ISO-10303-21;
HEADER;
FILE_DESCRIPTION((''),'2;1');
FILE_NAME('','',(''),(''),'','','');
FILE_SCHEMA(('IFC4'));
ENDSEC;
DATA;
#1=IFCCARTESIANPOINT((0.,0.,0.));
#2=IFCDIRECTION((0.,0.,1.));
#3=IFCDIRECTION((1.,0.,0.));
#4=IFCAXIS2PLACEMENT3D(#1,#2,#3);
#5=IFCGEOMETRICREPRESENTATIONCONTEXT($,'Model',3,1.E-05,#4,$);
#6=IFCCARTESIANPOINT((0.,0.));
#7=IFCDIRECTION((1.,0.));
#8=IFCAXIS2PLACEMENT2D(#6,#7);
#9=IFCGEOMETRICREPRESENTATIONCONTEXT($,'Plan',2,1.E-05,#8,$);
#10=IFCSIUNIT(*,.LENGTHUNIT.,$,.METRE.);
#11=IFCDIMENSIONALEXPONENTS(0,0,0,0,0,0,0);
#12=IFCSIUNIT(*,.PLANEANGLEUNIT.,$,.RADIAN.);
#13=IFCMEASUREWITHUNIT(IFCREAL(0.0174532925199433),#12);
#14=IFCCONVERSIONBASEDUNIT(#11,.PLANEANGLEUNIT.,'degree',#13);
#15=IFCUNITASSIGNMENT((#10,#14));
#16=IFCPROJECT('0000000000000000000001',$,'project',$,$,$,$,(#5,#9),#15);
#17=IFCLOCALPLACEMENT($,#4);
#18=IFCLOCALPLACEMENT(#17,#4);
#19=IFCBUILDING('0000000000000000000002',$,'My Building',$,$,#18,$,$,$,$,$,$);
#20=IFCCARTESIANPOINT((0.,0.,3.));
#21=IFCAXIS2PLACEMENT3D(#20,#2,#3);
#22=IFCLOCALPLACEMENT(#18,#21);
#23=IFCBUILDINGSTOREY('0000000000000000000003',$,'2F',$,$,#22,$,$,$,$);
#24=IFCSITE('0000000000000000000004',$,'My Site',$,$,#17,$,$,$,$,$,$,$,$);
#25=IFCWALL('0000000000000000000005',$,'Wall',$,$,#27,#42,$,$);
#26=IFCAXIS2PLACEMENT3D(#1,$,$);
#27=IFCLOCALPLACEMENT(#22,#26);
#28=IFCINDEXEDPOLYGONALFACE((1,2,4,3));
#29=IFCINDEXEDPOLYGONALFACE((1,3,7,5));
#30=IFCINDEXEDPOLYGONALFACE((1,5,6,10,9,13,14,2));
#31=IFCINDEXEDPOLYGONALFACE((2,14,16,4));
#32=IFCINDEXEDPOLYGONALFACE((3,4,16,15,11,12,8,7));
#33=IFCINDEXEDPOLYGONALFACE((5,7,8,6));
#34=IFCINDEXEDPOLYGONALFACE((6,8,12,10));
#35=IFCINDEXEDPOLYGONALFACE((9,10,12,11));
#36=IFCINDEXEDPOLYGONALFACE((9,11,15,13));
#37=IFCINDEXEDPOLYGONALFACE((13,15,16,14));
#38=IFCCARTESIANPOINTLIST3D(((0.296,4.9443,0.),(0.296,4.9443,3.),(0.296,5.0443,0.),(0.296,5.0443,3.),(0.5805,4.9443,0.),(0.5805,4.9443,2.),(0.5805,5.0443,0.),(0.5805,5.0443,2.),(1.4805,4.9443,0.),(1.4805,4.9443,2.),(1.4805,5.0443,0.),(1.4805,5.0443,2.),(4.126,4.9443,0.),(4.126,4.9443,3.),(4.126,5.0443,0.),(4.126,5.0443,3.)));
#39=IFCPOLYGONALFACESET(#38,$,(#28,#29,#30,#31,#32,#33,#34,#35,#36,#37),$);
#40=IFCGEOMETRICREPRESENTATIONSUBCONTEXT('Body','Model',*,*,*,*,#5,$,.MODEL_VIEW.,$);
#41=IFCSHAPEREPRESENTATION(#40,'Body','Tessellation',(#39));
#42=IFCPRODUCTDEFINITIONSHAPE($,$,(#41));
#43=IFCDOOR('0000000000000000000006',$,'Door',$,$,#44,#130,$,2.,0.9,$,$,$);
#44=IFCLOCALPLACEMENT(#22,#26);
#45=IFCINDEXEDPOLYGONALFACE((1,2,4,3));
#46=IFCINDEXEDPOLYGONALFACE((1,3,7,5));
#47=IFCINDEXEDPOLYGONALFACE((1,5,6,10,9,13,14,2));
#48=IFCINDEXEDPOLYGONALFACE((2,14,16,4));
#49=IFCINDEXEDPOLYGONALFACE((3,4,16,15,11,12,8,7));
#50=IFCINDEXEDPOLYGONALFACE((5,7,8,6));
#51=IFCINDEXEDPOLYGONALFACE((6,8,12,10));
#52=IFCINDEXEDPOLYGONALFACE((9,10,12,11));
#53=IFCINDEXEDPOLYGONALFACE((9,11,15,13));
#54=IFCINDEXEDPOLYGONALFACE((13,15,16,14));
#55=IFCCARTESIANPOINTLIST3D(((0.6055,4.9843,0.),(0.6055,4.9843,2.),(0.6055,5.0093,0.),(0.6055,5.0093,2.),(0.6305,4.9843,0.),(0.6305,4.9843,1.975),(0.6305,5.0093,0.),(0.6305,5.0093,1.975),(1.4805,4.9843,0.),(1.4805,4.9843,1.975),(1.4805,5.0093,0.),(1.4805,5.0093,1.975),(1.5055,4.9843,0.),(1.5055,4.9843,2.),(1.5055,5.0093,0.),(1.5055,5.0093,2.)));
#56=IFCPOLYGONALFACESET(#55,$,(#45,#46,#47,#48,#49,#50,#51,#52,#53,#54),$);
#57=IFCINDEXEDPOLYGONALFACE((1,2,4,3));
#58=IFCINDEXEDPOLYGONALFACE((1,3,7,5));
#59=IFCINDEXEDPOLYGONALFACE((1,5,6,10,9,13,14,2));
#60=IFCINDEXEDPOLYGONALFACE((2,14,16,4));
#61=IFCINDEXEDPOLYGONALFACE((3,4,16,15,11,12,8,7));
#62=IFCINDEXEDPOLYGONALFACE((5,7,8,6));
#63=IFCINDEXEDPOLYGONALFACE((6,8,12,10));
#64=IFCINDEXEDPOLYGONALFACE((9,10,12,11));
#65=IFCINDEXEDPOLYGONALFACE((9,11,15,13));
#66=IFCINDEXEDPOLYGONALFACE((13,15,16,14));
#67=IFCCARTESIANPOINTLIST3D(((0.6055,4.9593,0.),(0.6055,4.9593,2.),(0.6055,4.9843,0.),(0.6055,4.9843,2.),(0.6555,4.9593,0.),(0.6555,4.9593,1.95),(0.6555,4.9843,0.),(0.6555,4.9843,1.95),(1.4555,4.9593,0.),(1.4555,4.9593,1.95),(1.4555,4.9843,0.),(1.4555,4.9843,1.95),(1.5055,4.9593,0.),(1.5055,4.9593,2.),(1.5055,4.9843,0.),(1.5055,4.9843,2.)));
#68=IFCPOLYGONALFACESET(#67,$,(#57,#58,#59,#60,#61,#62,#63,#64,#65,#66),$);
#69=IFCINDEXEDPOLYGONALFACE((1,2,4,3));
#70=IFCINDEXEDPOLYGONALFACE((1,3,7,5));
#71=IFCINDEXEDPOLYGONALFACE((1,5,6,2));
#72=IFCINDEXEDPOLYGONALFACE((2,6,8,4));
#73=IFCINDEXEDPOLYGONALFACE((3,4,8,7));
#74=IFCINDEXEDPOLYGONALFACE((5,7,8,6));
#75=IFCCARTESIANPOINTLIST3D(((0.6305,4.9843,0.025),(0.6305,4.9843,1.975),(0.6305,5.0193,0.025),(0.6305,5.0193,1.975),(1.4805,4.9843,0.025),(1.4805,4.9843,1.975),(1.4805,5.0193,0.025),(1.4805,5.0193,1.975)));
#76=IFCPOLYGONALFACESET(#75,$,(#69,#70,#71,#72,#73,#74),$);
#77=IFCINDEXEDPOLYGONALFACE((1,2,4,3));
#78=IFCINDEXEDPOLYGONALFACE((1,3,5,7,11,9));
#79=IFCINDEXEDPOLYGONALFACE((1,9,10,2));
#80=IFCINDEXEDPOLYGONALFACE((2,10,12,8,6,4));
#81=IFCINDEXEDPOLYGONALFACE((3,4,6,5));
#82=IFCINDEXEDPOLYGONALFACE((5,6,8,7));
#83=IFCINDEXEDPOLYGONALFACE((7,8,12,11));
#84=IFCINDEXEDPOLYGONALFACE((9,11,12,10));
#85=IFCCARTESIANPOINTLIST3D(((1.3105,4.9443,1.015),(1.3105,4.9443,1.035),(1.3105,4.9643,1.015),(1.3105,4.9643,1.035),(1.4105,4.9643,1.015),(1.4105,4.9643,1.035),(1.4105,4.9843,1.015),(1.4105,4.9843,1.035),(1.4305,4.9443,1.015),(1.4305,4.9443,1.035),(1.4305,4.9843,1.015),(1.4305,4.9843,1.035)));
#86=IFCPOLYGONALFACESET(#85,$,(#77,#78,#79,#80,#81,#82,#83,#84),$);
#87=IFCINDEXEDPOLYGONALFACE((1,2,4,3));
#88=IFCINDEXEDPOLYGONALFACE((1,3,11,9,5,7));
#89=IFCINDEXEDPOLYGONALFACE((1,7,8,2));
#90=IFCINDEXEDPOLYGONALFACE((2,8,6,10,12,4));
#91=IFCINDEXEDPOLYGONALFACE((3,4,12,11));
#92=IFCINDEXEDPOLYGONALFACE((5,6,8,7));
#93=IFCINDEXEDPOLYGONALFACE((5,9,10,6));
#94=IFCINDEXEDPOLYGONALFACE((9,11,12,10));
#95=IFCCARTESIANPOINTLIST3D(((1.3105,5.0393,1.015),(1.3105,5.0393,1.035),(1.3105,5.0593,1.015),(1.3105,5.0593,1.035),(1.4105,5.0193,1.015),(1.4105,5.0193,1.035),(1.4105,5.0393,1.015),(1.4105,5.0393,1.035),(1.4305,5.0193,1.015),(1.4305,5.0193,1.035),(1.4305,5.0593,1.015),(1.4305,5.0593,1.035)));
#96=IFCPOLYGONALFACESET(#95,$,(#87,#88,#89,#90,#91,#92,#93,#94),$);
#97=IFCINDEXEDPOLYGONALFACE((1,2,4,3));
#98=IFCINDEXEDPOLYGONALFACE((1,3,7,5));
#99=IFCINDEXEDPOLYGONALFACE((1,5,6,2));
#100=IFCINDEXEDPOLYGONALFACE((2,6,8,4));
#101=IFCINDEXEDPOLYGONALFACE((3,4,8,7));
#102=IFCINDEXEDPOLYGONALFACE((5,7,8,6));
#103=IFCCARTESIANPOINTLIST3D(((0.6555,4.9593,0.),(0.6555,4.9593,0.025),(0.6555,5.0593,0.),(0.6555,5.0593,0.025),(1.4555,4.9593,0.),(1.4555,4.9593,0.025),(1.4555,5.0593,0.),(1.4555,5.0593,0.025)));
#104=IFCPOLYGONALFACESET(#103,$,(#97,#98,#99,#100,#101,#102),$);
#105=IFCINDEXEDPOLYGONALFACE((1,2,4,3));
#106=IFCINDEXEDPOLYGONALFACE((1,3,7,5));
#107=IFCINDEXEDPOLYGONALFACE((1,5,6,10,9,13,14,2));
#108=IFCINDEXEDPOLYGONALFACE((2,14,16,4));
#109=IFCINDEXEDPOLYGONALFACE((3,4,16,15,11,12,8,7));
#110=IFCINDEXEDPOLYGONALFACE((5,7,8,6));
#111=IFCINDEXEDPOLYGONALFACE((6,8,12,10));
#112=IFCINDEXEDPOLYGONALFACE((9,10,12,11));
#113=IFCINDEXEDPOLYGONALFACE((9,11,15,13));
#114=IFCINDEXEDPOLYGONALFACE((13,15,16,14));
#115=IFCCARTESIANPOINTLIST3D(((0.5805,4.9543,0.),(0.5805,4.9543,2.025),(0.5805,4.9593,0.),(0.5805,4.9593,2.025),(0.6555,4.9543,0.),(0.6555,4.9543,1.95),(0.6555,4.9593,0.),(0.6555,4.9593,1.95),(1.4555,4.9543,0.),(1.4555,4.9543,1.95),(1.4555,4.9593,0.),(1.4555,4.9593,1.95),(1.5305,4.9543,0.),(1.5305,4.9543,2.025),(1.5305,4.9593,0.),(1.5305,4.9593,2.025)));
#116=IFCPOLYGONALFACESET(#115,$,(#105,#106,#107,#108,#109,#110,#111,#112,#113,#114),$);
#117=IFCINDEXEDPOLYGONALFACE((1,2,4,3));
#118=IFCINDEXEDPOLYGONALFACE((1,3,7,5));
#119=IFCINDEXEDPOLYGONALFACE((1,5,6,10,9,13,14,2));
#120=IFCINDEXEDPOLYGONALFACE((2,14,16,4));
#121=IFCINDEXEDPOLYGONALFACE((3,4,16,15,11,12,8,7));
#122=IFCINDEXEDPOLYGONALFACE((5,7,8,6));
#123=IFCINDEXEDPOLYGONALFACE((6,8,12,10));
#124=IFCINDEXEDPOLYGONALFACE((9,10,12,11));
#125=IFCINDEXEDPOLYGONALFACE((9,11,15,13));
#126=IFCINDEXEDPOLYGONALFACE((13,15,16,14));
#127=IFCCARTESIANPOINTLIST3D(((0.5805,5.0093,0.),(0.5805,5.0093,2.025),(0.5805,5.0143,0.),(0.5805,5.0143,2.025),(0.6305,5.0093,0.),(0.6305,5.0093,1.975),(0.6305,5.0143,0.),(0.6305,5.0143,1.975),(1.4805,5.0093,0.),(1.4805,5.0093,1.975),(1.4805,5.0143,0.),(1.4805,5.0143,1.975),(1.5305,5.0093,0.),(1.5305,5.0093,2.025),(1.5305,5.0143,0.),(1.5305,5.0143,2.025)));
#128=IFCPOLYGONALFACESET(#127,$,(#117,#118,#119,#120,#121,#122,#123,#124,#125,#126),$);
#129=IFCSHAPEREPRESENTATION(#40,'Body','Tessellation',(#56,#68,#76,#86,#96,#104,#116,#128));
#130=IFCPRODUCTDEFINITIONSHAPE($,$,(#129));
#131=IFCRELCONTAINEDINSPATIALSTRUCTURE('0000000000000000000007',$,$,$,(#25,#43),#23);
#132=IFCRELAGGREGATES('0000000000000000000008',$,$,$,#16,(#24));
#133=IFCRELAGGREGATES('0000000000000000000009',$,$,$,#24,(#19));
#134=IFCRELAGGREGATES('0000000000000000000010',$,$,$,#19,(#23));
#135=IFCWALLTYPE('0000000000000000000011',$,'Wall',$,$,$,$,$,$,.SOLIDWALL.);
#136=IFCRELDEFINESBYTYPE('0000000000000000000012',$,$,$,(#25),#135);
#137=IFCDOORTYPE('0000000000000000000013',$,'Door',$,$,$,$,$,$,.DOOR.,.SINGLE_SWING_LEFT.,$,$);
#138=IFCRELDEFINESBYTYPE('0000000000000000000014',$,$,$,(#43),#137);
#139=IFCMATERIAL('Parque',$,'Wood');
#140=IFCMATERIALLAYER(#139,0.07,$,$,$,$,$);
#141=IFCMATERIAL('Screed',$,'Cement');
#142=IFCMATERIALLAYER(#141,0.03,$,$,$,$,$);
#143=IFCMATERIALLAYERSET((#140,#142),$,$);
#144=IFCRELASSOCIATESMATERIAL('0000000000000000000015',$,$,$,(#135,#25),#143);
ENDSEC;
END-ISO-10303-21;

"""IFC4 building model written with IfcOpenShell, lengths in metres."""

from ifc_helpers import new_model, entity, si_unit, converted_unit, frame, origin_with_axes, origin_2d_with_axis, place, context, subcontext, project, spatial, line, indexed_curve, outline, extrude, shape, source, transform, mapped, material, layer, layer_set, layer_usage, type_object, type_shapes, element, fill, save


model = new_model("IFC4")

# Units and contexts
model_context = context("Model", 3, precision=1e-05, world=origin_with_axes())
plan_context = context("Plan", 2, precision=1e-05, world=origin_2d_with_axis())
body_context_1 = subcontext(model_context, "Body", "Model", "MODEL_VIEW")
body_context_2 = subcontext(plan_context, "Body", "Plan", "PLAN_VIEW")
ifc_project = project(units=[si_unit("LENGTHUNIT", "METRE"), converted_unit("PLANEANGLEUNIT", "degree", entity("IfcReal", 0.0174532925199433), si_unit("PLANEANGLEUNIT", "RADIAN"), dimensions=[0, 0, 0, 0, 0, 0, 0])], contexts=[model_context, plan_context])

# Site, building, storey
site_placement = place(None, origin_with_axes())
site = spatial("IfcSite", under=ifc_project, at=site_placement, Name="My Site")
building_placement = place(site_placement, origin_with_axes())
building = spatial("IfcBuilding", under=site, at=building_placement, Name="My Building")
storey_placement = place(building_placement, frame((0.0, 0.0, 3.0), z_axis=(0.0, 0.0, 1.0), x_axis=(1.0, 0.0, 0.0)))
storey = spatial("IfcBuildingStorey", under=building, at=storey_placement, Name="2F")

# Shared definitions
ifc_material_1 = material(Name="Parque", Category="Wood")
ifc_layer_1 = layer(ifc_material_1, 0.07)
ifc_material_2 = material(Name="Screed", Category="Cement")
ifc_layer_2 = layer(ifc_material_2, 0.03)
ifc_layer_set = layer_set([ifc_layer_1, ifc_layer_2])
wall_type = type_object("IfcWallType", Name="Wall", PredefinedType="SOLIDWALL", material=ifc_layer_set)

# Wall, opening, door
shared_shape_1 = source(origin_with_axes(), body_context_1, "Body", "SweptSolid", [
    extrude(outline(indexed_curve([(0.0, 0.0), (0.9, 0.0), (0.9, 2.0), (0.0, 2.0)], segments=[line(1, 2, 3, 4, 1)])), frame((0.0, -0.6, 0.0), z_axis=(0.0, -1.0, 0.0), x_axis=(1.0, 0.0, 0.0)), (0.0, 0.0, -1.0), 1.2),
])
door_type_1 = type_object("IfcDoorType", Name="Door", OperationType="SINGLE_SWING_LEFT", PredefinedType="DOOR")
shared_shape_2 = source(origin_with_axes(), body_context_1, "Body", "SweptSolid", [
    extrude(outline(indexed_curve([(0.0, 0.0), (0.0, 2.0), (0.9, 2.0), (0.9, 0.0), (0.875, 0.0), (0.875, 1.975), (0.025, 1.975), (0.025, 0.0)], segments=[line(1, 2, 3, 4, 5, 6, 7, 8, 1)])), frame((0.0, 0.025, 0.0), z_axis=(0.0, -1.0, 0.0), x_axis=(1.0, 0.0, 0.0)), (0.0, 0.0, -1.0), 0.025),
    extrude(outline(indexed_curve([(0.0, 0.0), (0.0, 2.0), (0.9, 2.0), (0.9, 0.0), (0.85, 0.0), (0.85, 1.95), (0.05, 1.95), (0.05, 0.0)], segments=[line(1, 2, 3, 4, 5, 6, 7, 8, 1)])), frame((0.0, 0.0, 0.0), z_axis=(0.0, -1.0, 0.0), x_axis=(1.0, 0.0, 0.0)), (0.0, 0.0, -1.0), 0.025),
    extrude(outline(indexed_curve([(0.0, 0.0), (0.85, 0.0), (0.85, 0.035), (0.0, 0.035)], segments=[line(1, 2, 3, 4, 1)])), frame((0.025, 0.025, 0.025), z_axis=(0.0, 0.0, 1.0), x_axis=(1.0, 0.0, 0.0)), (0.0, 0.0, 1.0), 1.95),
    extrude(outline(indexed_curve([(0.0, 0.0), (0.0, -0.04), (-0.12, -0.04), (-0.12, -0.02), (-0.02, -0.02), (-0.02, 0.0)], segments=[line(1, 2, 3, 4, 5, 6, 1)])), frame((0.825, 0.025, 1.015), z_axis=(0.0, 0.0, 1.0), x_axis=(1.0, 0.0, 0.0)), (0.0, 0.0, 1.0), 0.02),
    extrude(outline(indexed_curve([(0.0, 0.0), (0.0, 0.04), (-0.12, 0.04), (-0.12, 0.02), (-0.02, 0.02), (-0.02, 0.0)], segments=[line(1, 2, 3, 4, 5, 6, 1)])), frame((0.825, 0.06, 1.015), z_axis=(0.0, 0.0, 1.0), x_axis=(1.0, 0.0, 0.0)), (0.0, 0.0, 1.0), 0.02),
    extrude(outline(indexed_curve([(0.0, 0.0), (0.8, 0.0), (0.8, 0.1), (0.0, 0.1)], segments=[line(1, 2, 3, 4, 1)])), frame((0.05, 0.0, 0.0), z_axis=(0.0, 0.0, 1.0), x_axis=(1.0, 0.0, 0.0)), (0.0, 0.0, 1.0), 0.025),
    extrude(outline(indexed_curve([(0.0, 0.0), (0.0, 2.025), (0.95, 2.025), (0.95, 0.0), (0.875, 0.0), (0.875, 1.95), (0.075, 1.95), (0.075, 0.0)], segments=[line(1, 2, 3, 4, 5, 6, 7, 8, 1)])), frame((-0.025, -0.005, 0.0), z_axis=(0.0, -1.0, 0.0), x_axis=(1.0, 0.0, 0.0)), (0.0, 0.0, -1.0), 0.005),
    extrude(outline(indexed_curve([(0.0, 0.0), (0.0, 2.025), (0.95, 2.025), (0.95, 0.0), (0.9, 0.0), (0.9, 1.975), (0.05, 1.975), (0.05, 0.0)], segments=[line(1, 2, 3, 4, 5, 6, 7, 8, 1)])), frame((-0.025, 0.05, 0.0), z_axis=(0.0, -1.0, 0.0), x_axis=(1.0, 0.0, 0.0)), (0.0, 0.0, -1.0), 0.005),
])
shared_shape_3 = source(origin_with_axes(), body_context_2, "Body", "Curve2D", [
    entity("IfcIndexedPolyCurve", entity("IfcCartesianPointList2D", [[0.0, 0.0], [0.0, 0.05], [0.025, 0.05], [0.025, 0.025], [0.05, 0.025], [0.05, 0.0]]), [entity("IfcLineIndex", [1, 2, 3, 4, 5, 6, 1])]),
    entity("IfcIndexedPolyCurve", entity("IfcCartesianPointList2D", [[0.9, 0.0], [0.9, 0.05], [0.875, 0.05], [0.875, 0.025], [0.85, 0.025], [0.85, 0.0]]), [entity("IfcLineIndex", [1, 2, 3, 4, 5, 6, 1])]),
    entity("IfcTrimmedCurve", entity("IfcEllipse", entity("IfcAxis2Placement2D", entity("IfcCartesianPoint", [0.06, 0.05]), entity("IfcDirection", [1.0, 0.0])), 0.815, 0.85), [entity("IfcCartesianPoint", [0.875, 0.05])], [entity("IfcCartesianPoint", [0.06, 0.9])], True, "CARTESIAN"),
    entity("IfcIndexedPolyCurve", entity("IfcCartesianPointList2D", [[0.025, 0.05], [0.06, 0.05], [0.06, 0.9], [0.025, 0.9]]), [entity("IfcLineIndex", [1, 2, 3, 4, 1])]),
])
type_shapes(door_type_1, [shared_shape_2, shared_shape_3])
ifc_layer_usage_1 = layer_usage(ifc_layer_set, "AXIS2", "POSITIVE", 0.0)
wall_1_placement = place(storey_placement, frame((4.126, 5.0443, 0.0), z_axis=(0.0, 0.0, 1.0), x_axis=(-1.0, -0.000001, 0.0)))
wall_1 = element("IfcWall", 1, at=wall_1_placement, inside=storey, type_object=wall_type, material=ifc_layer_usage_1, Name="Wall", context=body_context_1, shape_type="SweptSolid", body=[
    extrude(outline(indexed_curve([(0.0, 0.0), (0.0, 0.1), (3.83, 0.1), (3.83, 0.0)], segments=[line(1, 2, 3, 4, 1)])), origin_with_axes(), (0.0, 0.0, 1.0), 3.0),
])
opening_1_placement = place(wall_1_placement, frame((2.6455, 0.0, 0.0), z_axis=(0.0, 0.0, 1.0), x_axis=(1.0, 0.0, 0.0)))
opening_1 = element("IfcOpeningElement", 2, at=opening_1_placement, cuts=wall_1, PredefinedType="OPENING", context=body_context_1, shape_type="MappedRepresentation", body=[
    mapped(shared_shape_1, transform((0.0, 0.0, 0.0), x_axis=(1.0, 0.0, 0.0), y_axis=(0.0, 1.0, 0.0), z_axis=(0.0, 0.0, 1.0), scale=1.0)),
])
door_1_placement = place(opening_1_placement, frame((0.875, 0.085, 0.0), z_axis=(0.0, 0.0, 1.0), x_axis=(-1.0, 0.0, 0.0)))
door_1 = element("IfcDoor", 3, at=door_1_placement, inside=storey, type_object=door_type_1, Name="Door", OverallHeight=2.0, OverallWidth=0.9, shapes=[
    shape(body_context_1, "Body", "MappedRepresentation", [mapped(shared_shape_2, transform((0.0, 0.0, 0.0), x_axis=(1.0, 0.0, 0.0), y_axis=(0.0, 1.0, 0.0), z_axis=(0.0, 0.0, 1.0), scale=1.0))]),
    shape(body_context_2, "Body", "MappedRepresentation", [mapped(shared_shape_3, transform((0.0, 0.0, 0.0), x_axis=(1.0, 0.0, 0.0), y_axis=(0.0, 1.0, 0.0), z_axis=(0.0, 0.0, 1.0), scale=1.0))]),
])
fill(opening_1, door_1)

save(model, "model.ifc")
